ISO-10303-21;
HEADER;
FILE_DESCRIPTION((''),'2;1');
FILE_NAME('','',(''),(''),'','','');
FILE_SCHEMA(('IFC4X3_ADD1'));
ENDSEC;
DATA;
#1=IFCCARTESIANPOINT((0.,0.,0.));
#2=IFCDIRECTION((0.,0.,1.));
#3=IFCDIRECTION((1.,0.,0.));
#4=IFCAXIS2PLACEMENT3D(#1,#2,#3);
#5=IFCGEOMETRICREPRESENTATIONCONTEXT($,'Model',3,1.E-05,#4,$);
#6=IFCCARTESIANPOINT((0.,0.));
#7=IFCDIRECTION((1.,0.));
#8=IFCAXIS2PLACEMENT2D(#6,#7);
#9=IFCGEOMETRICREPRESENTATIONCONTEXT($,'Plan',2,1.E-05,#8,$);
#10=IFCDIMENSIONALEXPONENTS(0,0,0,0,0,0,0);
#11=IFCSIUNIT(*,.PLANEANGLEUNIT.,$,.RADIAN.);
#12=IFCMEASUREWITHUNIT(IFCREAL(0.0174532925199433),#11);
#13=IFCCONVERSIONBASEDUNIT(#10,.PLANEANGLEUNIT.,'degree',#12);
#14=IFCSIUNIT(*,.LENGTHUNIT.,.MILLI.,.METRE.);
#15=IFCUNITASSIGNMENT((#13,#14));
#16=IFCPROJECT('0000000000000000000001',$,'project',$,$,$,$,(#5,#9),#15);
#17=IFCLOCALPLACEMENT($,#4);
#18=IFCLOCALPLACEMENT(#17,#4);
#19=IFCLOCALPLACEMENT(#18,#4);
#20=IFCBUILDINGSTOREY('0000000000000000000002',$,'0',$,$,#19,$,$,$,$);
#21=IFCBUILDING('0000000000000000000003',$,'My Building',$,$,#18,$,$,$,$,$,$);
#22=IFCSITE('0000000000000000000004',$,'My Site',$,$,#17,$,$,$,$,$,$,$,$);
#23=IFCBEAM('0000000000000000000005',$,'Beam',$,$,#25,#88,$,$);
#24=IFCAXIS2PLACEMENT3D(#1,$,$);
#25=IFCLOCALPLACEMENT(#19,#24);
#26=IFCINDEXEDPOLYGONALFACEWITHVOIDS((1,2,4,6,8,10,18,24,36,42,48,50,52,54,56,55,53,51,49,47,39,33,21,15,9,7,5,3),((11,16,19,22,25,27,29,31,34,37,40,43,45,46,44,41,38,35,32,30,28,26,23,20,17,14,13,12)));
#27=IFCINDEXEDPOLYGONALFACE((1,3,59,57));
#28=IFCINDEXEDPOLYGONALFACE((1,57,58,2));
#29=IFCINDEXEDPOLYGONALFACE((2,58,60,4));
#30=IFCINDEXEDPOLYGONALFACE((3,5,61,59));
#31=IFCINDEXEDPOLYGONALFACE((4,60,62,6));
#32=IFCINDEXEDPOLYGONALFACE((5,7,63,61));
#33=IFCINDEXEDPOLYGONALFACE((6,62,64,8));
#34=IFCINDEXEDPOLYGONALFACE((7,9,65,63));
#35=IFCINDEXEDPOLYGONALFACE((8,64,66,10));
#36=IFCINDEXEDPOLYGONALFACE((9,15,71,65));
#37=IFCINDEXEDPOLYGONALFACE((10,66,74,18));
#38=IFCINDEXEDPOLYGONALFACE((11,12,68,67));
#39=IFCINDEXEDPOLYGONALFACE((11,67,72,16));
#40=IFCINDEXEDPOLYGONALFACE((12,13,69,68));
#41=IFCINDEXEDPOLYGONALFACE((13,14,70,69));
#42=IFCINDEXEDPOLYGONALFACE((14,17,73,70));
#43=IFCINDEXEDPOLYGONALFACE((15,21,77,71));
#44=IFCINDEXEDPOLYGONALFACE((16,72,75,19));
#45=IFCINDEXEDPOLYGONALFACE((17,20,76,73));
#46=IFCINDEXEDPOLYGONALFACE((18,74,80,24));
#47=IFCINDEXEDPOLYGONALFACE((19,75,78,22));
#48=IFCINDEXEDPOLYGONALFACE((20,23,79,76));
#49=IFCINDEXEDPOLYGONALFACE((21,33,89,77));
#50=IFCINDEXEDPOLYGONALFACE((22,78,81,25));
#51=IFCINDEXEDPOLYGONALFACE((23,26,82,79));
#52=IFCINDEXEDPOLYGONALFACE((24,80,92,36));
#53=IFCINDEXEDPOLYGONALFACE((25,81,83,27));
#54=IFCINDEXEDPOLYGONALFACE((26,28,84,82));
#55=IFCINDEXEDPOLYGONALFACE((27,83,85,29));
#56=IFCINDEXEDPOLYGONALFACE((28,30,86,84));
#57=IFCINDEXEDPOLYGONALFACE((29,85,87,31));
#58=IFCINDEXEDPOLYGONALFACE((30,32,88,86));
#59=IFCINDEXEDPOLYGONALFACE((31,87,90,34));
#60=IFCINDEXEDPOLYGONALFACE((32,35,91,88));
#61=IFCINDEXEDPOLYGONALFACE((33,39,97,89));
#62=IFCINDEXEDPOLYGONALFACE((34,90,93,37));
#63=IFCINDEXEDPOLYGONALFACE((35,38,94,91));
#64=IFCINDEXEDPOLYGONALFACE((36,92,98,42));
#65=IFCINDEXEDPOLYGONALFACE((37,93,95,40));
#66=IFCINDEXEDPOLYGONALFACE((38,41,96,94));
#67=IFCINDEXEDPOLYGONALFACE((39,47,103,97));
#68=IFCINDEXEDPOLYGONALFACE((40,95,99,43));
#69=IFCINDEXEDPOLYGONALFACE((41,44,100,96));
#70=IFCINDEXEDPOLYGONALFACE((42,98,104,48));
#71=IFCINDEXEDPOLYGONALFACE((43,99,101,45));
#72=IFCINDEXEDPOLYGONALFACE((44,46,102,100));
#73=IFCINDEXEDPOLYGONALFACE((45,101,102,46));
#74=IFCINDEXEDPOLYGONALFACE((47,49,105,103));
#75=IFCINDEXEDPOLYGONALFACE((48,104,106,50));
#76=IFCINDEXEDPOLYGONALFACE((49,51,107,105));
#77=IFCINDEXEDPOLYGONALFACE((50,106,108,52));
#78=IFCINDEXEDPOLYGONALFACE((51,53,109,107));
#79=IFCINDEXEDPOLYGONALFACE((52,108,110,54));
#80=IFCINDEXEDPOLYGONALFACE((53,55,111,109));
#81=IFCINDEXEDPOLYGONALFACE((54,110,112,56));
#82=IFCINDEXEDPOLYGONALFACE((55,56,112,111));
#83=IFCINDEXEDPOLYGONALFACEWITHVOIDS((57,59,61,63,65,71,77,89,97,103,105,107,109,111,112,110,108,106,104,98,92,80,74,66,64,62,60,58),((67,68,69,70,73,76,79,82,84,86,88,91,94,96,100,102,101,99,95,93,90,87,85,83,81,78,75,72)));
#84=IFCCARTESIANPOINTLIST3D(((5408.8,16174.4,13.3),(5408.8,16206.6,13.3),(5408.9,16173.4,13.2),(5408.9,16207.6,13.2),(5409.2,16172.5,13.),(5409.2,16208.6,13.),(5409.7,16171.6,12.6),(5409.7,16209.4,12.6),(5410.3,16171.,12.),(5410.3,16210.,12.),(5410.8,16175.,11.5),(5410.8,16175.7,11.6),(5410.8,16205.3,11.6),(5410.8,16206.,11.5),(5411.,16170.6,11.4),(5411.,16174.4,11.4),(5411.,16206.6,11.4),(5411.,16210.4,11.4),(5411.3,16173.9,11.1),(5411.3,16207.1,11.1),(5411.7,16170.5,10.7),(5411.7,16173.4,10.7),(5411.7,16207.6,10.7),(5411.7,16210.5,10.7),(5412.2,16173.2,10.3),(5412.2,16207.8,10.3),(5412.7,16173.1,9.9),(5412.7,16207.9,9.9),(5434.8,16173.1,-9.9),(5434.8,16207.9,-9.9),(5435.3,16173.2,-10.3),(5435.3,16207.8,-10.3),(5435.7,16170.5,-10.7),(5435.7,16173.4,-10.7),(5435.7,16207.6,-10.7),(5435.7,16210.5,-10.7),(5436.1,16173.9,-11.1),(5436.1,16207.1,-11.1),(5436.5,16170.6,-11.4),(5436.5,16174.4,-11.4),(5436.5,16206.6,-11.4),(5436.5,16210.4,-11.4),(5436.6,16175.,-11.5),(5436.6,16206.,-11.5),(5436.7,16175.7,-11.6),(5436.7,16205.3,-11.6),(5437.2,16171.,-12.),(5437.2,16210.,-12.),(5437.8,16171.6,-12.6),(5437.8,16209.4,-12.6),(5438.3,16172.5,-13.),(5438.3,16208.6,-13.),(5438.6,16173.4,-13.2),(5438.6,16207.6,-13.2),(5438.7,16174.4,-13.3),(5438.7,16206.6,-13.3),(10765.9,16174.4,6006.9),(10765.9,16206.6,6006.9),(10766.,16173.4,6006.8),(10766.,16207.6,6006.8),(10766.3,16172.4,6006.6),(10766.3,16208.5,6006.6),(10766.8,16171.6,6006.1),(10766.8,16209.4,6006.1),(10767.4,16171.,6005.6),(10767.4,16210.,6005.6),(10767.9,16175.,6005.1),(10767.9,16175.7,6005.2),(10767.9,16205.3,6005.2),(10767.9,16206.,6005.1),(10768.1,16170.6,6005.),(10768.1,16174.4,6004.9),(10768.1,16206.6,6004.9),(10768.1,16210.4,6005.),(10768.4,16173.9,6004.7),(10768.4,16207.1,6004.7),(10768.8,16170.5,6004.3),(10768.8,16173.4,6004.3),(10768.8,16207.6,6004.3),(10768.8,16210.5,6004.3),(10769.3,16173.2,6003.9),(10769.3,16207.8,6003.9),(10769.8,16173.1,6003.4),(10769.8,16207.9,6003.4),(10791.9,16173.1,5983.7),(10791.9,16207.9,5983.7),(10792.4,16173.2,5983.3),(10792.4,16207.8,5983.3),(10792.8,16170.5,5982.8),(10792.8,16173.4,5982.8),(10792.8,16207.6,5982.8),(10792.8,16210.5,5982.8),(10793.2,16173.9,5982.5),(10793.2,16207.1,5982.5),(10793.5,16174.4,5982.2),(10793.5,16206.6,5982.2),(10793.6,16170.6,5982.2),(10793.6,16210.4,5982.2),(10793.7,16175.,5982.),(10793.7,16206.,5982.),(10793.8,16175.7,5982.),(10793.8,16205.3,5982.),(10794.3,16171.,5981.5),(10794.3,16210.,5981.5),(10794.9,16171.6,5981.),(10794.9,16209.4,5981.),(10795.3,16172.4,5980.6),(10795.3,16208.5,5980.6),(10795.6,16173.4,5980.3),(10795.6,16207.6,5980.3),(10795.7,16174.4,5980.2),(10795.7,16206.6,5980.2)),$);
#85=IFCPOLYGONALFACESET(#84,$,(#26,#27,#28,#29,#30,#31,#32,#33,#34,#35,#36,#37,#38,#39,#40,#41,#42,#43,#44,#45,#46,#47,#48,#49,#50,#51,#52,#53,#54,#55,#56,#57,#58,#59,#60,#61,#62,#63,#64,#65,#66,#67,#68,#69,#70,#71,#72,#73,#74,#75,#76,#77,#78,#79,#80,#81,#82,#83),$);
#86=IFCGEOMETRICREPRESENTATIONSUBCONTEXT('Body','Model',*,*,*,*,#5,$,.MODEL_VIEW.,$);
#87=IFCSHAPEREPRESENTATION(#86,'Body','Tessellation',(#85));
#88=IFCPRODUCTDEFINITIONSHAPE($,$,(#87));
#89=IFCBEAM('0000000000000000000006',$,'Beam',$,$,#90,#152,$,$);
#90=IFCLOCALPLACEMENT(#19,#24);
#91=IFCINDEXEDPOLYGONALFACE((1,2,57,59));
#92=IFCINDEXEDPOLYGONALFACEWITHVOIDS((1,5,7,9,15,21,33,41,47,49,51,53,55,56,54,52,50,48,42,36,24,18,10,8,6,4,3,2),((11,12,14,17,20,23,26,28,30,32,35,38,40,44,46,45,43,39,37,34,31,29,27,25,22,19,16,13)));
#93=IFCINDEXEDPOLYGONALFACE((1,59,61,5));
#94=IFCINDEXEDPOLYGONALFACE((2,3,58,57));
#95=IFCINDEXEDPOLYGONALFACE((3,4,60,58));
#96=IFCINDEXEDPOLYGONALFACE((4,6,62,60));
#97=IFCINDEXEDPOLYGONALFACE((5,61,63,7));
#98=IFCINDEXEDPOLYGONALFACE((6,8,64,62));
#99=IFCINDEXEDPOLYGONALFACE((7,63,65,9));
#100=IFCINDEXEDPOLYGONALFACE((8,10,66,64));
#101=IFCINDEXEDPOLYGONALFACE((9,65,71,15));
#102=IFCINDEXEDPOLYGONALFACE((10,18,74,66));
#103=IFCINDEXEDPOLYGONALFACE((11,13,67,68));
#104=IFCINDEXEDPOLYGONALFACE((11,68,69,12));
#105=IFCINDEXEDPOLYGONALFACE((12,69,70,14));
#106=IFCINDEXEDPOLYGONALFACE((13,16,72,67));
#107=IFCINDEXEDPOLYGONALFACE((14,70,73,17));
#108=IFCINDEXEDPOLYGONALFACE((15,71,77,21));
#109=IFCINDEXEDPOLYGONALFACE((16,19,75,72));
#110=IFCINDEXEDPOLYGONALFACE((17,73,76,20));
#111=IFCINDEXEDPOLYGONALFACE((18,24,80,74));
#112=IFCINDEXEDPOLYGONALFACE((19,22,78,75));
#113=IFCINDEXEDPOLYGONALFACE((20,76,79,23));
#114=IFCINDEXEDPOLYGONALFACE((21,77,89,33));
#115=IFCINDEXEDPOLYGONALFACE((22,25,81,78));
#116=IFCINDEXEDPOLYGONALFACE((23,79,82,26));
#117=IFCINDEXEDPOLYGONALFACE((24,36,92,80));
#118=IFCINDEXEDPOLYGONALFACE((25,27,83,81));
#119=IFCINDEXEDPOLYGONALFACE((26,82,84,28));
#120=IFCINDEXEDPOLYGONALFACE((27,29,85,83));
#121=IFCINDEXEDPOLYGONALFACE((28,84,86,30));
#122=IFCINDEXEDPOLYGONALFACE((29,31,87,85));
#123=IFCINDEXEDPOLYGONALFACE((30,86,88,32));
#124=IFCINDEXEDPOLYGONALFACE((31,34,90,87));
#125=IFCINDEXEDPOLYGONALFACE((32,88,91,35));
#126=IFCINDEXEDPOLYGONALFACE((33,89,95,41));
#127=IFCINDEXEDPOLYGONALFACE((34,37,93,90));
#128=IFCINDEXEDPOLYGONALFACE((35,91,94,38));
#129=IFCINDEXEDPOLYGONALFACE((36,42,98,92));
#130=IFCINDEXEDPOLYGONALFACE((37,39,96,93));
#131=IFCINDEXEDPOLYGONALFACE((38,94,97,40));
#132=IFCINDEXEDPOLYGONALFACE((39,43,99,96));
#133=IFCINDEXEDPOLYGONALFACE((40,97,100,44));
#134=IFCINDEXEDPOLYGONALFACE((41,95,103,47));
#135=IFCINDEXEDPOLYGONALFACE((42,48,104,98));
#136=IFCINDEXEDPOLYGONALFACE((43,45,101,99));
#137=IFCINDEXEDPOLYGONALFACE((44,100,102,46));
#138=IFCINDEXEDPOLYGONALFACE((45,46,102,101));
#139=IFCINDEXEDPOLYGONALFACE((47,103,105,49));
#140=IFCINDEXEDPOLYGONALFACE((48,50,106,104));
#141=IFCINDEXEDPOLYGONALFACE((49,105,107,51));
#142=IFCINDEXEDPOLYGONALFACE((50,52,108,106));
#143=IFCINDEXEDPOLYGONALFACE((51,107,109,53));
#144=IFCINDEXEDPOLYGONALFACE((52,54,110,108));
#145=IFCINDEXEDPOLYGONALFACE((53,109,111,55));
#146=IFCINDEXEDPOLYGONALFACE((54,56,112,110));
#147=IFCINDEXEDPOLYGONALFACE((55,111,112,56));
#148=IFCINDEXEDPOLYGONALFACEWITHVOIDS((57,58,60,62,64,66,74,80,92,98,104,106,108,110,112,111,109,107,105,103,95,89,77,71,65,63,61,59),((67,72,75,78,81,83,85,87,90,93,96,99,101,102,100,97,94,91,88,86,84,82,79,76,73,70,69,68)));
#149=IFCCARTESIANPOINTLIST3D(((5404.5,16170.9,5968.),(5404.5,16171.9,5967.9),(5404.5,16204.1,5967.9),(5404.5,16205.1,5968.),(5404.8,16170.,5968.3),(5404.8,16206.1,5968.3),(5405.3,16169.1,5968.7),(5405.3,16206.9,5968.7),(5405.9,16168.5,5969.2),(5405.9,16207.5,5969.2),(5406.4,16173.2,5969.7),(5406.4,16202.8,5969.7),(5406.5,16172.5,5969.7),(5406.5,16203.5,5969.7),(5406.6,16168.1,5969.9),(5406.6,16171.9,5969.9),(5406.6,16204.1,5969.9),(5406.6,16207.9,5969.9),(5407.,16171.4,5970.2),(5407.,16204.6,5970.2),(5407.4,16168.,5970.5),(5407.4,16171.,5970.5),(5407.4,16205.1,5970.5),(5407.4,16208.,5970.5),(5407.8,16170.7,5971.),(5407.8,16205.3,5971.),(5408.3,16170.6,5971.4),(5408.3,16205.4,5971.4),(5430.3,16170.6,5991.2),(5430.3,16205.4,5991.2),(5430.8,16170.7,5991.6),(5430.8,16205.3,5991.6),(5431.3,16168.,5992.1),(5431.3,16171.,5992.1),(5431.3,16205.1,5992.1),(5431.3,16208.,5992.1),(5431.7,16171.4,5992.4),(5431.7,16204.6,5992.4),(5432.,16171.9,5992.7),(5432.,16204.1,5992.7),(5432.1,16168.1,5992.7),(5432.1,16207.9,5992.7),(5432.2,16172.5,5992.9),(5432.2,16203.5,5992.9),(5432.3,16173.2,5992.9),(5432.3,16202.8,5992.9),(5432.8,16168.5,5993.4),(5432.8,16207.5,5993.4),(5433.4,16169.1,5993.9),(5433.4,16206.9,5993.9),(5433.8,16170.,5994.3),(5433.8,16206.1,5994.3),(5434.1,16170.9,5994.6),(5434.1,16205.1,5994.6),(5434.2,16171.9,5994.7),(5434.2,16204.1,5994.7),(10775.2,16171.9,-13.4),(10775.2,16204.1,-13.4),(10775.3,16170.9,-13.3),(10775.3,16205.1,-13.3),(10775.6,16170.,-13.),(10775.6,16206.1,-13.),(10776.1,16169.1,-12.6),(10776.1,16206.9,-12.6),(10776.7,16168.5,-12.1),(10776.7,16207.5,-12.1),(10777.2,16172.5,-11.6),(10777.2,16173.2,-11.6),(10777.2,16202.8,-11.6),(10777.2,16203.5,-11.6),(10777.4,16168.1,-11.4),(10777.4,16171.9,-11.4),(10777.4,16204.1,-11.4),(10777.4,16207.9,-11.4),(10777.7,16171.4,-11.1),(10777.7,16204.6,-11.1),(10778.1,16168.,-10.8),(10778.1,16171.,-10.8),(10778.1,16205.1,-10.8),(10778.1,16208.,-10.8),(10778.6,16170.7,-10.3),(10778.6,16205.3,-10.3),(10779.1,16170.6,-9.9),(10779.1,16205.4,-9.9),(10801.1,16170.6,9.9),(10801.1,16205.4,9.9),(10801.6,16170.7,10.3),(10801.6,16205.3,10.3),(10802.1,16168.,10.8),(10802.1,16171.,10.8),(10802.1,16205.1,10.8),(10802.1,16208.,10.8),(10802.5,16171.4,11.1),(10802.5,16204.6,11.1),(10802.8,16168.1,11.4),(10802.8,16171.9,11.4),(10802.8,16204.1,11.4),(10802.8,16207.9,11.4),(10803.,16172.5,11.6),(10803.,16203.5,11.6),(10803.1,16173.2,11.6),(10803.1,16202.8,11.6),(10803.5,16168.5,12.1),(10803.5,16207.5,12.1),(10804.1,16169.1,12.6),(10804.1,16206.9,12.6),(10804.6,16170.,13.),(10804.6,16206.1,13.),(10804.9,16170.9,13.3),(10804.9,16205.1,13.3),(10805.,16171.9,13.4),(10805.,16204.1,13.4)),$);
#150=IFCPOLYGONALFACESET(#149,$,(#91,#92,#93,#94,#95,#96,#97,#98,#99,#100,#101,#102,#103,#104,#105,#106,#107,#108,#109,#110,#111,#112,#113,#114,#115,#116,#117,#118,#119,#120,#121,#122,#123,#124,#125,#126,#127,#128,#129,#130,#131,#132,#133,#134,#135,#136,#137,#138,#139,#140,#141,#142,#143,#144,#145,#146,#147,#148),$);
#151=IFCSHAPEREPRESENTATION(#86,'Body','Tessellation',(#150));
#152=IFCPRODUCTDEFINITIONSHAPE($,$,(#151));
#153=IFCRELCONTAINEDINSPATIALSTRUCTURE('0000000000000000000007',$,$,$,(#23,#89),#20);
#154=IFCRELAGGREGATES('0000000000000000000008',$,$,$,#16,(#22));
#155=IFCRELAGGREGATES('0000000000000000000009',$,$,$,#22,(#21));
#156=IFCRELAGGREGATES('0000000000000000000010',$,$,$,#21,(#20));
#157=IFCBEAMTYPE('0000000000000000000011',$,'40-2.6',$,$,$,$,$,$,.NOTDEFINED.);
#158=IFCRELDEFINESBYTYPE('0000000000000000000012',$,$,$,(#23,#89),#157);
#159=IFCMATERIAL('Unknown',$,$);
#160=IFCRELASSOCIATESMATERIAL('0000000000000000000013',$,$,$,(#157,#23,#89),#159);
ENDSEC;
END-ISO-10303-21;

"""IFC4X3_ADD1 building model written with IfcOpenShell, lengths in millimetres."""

from ifc_helpers import new_model, entity, si_unit, converted_unit, frame, origin_with_axes, origin_2d_with_axis, place, context, subcontext, project, spatial, hollow_rectangle, extrude, material, material_profile, profile_set, profile_usage, type_object, element, save


model = new_model("IFC4X3_ADD1")

# Units and contexts
model_context = context("Model", 3, precision=1e-05, world=origin_with_axes())
plan_context = context("Plan", 2, precision=1e-05, world=origin_2d_with_axis())
body_context = subcontext(model_context, "Body", "Model", "MODEL_VIEW")
ifc_project = project(units=[converted_unit("PLANEANGLEUNIT", "degree", entity("IfcReal", 0.0174532925199433), si_unit("PLANEANGLEUNIT", "RADIAN"), dimensions=[0, 0, 0, 0, 0, 0, 0]), si_unit("LENGTHUNIT", "METRE", prefix="MILLI")], contexts=[model_context, plan_context])

# Site, building, storey
site_placement = place(None, origin_with_axes())
site = spatial("IfcSite", under=ifc_project, at=site_placement, Name="My Site")
building_placement = place(site_placement, origin_with_axes())
building = spatial("IfcBuilding", under=site, at=building_placement, Name="My Building")
storey_placement = place(building_placement, origin_with_axes())
storey = spatial("IfcBuildingStorey", under=building, at=storey_placement, Name="0")

# Shared definitions
ifc_material = material(Name="Unknown")

# Beams
ifc_material_profile_1 = material_profile(ifc_material, hollow_rectangle(XDim=40.0, YDim=40.0, WallThickness=2.6, InnerFilletRadius=2.6, OuterFilletRadius=3.9))
ifc_profile_set_1 = profile_set([ifc_material_profile_1])
beam_type = type_object("IfcBeamType", Name="40-2.6", PredefinedType="NOTDEFINED", material=ifc_profile_set_1)
ifc_profile_usage_1 = profile_usage(ifc_profile_set_1, cardinal=5)
beam_1_placement = place(storey_placement, frame((5423.7, 16190.5, 0.0), z_axis=(0.666409, 0.0, 0.745587), x_axis=(0.0, 1.0, 0.0)))
element("IfcBeam", 1, at=beam_1_placement, inside=storey, type_object=beam_type, material=ifc_profile_usage_1, Name="Beam", context=body_context, shape_type="SweptSolid", body=[
    extrude(hollow_rectangle(XDim=40.0, YDim=40.0, WallThickness=2.6, InnerFilletRadius=2.6, OuterFilletRadius=3.9), origin_with_axes(), (0.0, 0.0, 1.0), 8038.7),
])
ifc_profile_usage_2 = profile_usage(ifc_profile_set_1, cardinal=5)
beam_2_placement = place(storey_placement, frame((10790.1, 16188.0, 0.0), z_axis=(-0.668113, 0.0, 0.74406), x_axis=(0.0, 1.0, 0.0)))
element("IfcBeam", 2, at=beam_2_placement, inside=storey, type_object=beam_type, material=ifc_profile_usage_2, Name="Beam", context=body_context, shape_type="SweptSolid", body=[
    extrude(hollow_rectangle(XDim=40.0, YDim=40.0, WallThickness=2.6, InnerFilletRadius=2.6, OuterFilletRadius=3.9), origin_with_axes(), (0.0, 0.0, 1.0), 8038.7),
])

save(model, "model.ifc")
